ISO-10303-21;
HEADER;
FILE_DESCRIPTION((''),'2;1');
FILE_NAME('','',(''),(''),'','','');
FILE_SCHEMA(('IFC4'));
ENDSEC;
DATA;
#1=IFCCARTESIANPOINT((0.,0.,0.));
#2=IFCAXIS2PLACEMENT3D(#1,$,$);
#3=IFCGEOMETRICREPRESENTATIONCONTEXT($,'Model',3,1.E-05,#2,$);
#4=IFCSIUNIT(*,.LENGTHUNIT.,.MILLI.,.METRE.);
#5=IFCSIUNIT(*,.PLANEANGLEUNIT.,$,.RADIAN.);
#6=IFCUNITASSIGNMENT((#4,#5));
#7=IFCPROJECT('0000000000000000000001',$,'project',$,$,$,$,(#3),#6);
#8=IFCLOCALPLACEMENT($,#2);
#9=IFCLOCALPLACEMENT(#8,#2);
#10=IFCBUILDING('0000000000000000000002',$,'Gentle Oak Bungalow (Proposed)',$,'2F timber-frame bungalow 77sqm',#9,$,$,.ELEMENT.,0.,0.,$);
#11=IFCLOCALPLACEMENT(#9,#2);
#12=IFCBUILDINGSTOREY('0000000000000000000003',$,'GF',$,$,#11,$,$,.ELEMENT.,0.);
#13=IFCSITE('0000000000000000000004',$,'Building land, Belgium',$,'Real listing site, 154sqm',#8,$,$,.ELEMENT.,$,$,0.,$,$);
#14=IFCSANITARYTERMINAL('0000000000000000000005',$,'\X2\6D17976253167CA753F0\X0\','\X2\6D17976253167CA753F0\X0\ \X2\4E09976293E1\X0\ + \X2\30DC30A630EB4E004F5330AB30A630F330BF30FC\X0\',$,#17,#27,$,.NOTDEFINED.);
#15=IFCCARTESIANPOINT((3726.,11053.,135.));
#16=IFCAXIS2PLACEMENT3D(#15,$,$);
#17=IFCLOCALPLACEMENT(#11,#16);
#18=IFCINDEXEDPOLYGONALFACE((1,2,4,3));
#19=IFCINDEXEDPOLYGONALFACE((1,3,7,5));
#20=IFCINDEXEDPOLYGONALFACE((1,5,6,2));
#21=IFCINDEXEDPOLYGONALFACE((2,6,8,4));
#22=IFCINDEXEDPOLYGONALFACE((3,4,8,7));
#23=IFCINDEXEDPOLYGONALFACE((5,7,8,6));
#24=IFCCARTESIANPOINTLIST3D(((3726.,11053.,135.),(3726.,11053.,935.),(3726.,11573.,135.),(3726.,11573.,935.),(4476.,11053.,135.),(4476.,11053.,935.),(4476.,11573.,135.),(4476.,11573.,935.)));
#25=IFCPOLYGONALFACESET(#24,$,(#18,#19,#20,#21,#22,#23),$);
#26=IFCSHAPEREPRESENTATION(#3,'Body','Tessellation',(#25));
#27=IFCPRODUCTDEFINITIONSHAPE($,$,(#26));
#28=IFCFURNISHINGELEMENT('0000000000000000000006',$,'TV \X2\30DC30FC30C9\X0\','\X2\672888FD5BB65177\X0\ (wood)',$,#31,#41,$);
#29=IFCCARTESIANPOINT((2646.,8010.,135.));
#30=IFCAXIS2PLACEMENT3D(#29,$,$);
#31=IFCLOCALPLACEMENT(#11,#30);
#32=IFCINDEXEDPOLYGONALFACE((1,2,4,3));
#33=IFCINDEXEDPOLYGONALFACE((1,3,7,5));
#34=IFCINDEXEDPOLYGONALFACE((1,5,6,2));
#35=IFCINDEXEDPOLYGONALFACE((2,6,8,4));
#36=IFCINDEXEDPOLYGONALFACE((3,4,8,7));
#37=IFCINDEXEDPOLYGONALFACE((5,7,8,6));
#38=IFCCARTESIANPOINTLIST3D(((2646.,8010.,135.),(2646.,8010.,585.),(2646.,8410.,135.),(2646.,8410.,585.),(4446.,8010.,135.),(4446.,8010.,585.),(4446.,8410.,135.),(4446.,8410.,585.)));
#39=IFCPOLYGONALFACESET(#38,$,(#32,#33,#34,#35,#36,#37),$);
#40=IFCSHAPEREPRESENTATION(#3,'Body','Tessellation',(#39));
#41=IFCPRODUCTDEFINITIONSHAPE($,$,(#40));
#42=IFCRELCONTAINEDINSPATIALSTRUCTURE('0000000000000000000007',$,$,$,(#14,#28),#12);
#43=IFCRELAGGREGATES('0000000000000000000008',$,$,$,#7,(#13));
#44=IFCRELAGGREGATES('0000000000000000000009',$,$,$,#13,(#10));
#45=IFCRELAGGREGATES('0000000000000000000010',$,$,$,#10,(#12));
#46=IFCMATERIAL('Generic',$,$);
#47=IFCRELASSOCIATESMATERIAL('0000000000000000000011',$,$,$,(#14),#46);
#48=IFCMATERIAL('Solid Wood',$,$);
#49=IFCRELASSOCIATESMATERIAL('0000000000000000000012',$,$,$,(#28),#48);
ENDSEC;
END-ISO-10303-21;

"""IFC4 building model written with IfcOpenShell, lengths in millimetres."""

from ifc_helpers import new_model, si_unit, frame, frame_2d, origin, place, context, project, spatial, rectangle, extrude, material, element, save


model = new_model("IFC4")

# Units and contexts
model_context = context("Model", 3, precision=1e-05, world=origin())
ifc_project = project(units=[si_unit("LENGTHUNIT", "METRE", prefix="MILLI"), si_unit("PLANEANGLEUNIT", "RADIAN")], contexts=[model_context])

# Site, building, storey
site_placement = place(None, origin())
site = spatial("IfcSite", under=ifc_project, at=site_placement, Name="Building land, Belgium", ObjectType="Real listing site, 154sqm", CompositionType="ELEMENT", RefElevation=0.0)
building_placement = place(site_placement, origin())
building = spatial("IfcBuilding", under=site, at=building_placement, Name="Gentle Oak Bungalow (Proposed)", ObjectType="2F timber-frame bungalow 77sqm", CompositionType="ELEMENT", ElevationOfRefHeight=0.0, ElevationOfTerrain=0.0)
storey_placement = place(building_placement, origin())
storey = spatial("IfcBuildingStorey", under=building, at=storey_placement, Name="GF", CompositionType="ELEMENT", Elevation=0.0)

# Shared definitions
ifc_material_1 = material(Name="Solid Wood")

# Shared definitions
ifc_material_2 = material(Name="Generic")

# Sanitary terminal
sanitary_terminal_1_placement = place(storey_placement, frame((3726.0, 11053.0, 135.0)))
element("IfcSanitaryTerminal", 1, at=sanitary_terminal_1_placement, inside=storey, material=ifc_material_2, Name="洗面化粧台", Description="洗面化粧台 三面鏡 + ボウル一体カウンター", PredefinedType="NOTDEFINED", context=model_context, shape_type="SweptSolid", body=[
    extrude(rectangle(XDim=750.0, YDim=520.0, at=frame_2d((375.0, 260.0))), frame((3726.0, 11053.0, 135.0)), (0.0, 0.0, 1.0), 800.0),
])

# Furnishing element
furnishing_placement = place(storey_placement, frame((2646.0, 8010.0, 135.0)))
element("IfcFurnishingElement", 2, at=furnishing_placement, inside=storey, material=ifc_material_1, Name="TV ボード", Description="木製家具 (wood)", context=model_context, shape_type="SweptSolid", body=[
    extrude(rectangle(XDim=1800.0, YDim=400.0, at=frame_2d((900.0, 200.0))), frame((2646.0, 8010.0, 135.0)), (0.0, 0.0, 1.0), 450.0),
])

save(model, "model.ifc")
